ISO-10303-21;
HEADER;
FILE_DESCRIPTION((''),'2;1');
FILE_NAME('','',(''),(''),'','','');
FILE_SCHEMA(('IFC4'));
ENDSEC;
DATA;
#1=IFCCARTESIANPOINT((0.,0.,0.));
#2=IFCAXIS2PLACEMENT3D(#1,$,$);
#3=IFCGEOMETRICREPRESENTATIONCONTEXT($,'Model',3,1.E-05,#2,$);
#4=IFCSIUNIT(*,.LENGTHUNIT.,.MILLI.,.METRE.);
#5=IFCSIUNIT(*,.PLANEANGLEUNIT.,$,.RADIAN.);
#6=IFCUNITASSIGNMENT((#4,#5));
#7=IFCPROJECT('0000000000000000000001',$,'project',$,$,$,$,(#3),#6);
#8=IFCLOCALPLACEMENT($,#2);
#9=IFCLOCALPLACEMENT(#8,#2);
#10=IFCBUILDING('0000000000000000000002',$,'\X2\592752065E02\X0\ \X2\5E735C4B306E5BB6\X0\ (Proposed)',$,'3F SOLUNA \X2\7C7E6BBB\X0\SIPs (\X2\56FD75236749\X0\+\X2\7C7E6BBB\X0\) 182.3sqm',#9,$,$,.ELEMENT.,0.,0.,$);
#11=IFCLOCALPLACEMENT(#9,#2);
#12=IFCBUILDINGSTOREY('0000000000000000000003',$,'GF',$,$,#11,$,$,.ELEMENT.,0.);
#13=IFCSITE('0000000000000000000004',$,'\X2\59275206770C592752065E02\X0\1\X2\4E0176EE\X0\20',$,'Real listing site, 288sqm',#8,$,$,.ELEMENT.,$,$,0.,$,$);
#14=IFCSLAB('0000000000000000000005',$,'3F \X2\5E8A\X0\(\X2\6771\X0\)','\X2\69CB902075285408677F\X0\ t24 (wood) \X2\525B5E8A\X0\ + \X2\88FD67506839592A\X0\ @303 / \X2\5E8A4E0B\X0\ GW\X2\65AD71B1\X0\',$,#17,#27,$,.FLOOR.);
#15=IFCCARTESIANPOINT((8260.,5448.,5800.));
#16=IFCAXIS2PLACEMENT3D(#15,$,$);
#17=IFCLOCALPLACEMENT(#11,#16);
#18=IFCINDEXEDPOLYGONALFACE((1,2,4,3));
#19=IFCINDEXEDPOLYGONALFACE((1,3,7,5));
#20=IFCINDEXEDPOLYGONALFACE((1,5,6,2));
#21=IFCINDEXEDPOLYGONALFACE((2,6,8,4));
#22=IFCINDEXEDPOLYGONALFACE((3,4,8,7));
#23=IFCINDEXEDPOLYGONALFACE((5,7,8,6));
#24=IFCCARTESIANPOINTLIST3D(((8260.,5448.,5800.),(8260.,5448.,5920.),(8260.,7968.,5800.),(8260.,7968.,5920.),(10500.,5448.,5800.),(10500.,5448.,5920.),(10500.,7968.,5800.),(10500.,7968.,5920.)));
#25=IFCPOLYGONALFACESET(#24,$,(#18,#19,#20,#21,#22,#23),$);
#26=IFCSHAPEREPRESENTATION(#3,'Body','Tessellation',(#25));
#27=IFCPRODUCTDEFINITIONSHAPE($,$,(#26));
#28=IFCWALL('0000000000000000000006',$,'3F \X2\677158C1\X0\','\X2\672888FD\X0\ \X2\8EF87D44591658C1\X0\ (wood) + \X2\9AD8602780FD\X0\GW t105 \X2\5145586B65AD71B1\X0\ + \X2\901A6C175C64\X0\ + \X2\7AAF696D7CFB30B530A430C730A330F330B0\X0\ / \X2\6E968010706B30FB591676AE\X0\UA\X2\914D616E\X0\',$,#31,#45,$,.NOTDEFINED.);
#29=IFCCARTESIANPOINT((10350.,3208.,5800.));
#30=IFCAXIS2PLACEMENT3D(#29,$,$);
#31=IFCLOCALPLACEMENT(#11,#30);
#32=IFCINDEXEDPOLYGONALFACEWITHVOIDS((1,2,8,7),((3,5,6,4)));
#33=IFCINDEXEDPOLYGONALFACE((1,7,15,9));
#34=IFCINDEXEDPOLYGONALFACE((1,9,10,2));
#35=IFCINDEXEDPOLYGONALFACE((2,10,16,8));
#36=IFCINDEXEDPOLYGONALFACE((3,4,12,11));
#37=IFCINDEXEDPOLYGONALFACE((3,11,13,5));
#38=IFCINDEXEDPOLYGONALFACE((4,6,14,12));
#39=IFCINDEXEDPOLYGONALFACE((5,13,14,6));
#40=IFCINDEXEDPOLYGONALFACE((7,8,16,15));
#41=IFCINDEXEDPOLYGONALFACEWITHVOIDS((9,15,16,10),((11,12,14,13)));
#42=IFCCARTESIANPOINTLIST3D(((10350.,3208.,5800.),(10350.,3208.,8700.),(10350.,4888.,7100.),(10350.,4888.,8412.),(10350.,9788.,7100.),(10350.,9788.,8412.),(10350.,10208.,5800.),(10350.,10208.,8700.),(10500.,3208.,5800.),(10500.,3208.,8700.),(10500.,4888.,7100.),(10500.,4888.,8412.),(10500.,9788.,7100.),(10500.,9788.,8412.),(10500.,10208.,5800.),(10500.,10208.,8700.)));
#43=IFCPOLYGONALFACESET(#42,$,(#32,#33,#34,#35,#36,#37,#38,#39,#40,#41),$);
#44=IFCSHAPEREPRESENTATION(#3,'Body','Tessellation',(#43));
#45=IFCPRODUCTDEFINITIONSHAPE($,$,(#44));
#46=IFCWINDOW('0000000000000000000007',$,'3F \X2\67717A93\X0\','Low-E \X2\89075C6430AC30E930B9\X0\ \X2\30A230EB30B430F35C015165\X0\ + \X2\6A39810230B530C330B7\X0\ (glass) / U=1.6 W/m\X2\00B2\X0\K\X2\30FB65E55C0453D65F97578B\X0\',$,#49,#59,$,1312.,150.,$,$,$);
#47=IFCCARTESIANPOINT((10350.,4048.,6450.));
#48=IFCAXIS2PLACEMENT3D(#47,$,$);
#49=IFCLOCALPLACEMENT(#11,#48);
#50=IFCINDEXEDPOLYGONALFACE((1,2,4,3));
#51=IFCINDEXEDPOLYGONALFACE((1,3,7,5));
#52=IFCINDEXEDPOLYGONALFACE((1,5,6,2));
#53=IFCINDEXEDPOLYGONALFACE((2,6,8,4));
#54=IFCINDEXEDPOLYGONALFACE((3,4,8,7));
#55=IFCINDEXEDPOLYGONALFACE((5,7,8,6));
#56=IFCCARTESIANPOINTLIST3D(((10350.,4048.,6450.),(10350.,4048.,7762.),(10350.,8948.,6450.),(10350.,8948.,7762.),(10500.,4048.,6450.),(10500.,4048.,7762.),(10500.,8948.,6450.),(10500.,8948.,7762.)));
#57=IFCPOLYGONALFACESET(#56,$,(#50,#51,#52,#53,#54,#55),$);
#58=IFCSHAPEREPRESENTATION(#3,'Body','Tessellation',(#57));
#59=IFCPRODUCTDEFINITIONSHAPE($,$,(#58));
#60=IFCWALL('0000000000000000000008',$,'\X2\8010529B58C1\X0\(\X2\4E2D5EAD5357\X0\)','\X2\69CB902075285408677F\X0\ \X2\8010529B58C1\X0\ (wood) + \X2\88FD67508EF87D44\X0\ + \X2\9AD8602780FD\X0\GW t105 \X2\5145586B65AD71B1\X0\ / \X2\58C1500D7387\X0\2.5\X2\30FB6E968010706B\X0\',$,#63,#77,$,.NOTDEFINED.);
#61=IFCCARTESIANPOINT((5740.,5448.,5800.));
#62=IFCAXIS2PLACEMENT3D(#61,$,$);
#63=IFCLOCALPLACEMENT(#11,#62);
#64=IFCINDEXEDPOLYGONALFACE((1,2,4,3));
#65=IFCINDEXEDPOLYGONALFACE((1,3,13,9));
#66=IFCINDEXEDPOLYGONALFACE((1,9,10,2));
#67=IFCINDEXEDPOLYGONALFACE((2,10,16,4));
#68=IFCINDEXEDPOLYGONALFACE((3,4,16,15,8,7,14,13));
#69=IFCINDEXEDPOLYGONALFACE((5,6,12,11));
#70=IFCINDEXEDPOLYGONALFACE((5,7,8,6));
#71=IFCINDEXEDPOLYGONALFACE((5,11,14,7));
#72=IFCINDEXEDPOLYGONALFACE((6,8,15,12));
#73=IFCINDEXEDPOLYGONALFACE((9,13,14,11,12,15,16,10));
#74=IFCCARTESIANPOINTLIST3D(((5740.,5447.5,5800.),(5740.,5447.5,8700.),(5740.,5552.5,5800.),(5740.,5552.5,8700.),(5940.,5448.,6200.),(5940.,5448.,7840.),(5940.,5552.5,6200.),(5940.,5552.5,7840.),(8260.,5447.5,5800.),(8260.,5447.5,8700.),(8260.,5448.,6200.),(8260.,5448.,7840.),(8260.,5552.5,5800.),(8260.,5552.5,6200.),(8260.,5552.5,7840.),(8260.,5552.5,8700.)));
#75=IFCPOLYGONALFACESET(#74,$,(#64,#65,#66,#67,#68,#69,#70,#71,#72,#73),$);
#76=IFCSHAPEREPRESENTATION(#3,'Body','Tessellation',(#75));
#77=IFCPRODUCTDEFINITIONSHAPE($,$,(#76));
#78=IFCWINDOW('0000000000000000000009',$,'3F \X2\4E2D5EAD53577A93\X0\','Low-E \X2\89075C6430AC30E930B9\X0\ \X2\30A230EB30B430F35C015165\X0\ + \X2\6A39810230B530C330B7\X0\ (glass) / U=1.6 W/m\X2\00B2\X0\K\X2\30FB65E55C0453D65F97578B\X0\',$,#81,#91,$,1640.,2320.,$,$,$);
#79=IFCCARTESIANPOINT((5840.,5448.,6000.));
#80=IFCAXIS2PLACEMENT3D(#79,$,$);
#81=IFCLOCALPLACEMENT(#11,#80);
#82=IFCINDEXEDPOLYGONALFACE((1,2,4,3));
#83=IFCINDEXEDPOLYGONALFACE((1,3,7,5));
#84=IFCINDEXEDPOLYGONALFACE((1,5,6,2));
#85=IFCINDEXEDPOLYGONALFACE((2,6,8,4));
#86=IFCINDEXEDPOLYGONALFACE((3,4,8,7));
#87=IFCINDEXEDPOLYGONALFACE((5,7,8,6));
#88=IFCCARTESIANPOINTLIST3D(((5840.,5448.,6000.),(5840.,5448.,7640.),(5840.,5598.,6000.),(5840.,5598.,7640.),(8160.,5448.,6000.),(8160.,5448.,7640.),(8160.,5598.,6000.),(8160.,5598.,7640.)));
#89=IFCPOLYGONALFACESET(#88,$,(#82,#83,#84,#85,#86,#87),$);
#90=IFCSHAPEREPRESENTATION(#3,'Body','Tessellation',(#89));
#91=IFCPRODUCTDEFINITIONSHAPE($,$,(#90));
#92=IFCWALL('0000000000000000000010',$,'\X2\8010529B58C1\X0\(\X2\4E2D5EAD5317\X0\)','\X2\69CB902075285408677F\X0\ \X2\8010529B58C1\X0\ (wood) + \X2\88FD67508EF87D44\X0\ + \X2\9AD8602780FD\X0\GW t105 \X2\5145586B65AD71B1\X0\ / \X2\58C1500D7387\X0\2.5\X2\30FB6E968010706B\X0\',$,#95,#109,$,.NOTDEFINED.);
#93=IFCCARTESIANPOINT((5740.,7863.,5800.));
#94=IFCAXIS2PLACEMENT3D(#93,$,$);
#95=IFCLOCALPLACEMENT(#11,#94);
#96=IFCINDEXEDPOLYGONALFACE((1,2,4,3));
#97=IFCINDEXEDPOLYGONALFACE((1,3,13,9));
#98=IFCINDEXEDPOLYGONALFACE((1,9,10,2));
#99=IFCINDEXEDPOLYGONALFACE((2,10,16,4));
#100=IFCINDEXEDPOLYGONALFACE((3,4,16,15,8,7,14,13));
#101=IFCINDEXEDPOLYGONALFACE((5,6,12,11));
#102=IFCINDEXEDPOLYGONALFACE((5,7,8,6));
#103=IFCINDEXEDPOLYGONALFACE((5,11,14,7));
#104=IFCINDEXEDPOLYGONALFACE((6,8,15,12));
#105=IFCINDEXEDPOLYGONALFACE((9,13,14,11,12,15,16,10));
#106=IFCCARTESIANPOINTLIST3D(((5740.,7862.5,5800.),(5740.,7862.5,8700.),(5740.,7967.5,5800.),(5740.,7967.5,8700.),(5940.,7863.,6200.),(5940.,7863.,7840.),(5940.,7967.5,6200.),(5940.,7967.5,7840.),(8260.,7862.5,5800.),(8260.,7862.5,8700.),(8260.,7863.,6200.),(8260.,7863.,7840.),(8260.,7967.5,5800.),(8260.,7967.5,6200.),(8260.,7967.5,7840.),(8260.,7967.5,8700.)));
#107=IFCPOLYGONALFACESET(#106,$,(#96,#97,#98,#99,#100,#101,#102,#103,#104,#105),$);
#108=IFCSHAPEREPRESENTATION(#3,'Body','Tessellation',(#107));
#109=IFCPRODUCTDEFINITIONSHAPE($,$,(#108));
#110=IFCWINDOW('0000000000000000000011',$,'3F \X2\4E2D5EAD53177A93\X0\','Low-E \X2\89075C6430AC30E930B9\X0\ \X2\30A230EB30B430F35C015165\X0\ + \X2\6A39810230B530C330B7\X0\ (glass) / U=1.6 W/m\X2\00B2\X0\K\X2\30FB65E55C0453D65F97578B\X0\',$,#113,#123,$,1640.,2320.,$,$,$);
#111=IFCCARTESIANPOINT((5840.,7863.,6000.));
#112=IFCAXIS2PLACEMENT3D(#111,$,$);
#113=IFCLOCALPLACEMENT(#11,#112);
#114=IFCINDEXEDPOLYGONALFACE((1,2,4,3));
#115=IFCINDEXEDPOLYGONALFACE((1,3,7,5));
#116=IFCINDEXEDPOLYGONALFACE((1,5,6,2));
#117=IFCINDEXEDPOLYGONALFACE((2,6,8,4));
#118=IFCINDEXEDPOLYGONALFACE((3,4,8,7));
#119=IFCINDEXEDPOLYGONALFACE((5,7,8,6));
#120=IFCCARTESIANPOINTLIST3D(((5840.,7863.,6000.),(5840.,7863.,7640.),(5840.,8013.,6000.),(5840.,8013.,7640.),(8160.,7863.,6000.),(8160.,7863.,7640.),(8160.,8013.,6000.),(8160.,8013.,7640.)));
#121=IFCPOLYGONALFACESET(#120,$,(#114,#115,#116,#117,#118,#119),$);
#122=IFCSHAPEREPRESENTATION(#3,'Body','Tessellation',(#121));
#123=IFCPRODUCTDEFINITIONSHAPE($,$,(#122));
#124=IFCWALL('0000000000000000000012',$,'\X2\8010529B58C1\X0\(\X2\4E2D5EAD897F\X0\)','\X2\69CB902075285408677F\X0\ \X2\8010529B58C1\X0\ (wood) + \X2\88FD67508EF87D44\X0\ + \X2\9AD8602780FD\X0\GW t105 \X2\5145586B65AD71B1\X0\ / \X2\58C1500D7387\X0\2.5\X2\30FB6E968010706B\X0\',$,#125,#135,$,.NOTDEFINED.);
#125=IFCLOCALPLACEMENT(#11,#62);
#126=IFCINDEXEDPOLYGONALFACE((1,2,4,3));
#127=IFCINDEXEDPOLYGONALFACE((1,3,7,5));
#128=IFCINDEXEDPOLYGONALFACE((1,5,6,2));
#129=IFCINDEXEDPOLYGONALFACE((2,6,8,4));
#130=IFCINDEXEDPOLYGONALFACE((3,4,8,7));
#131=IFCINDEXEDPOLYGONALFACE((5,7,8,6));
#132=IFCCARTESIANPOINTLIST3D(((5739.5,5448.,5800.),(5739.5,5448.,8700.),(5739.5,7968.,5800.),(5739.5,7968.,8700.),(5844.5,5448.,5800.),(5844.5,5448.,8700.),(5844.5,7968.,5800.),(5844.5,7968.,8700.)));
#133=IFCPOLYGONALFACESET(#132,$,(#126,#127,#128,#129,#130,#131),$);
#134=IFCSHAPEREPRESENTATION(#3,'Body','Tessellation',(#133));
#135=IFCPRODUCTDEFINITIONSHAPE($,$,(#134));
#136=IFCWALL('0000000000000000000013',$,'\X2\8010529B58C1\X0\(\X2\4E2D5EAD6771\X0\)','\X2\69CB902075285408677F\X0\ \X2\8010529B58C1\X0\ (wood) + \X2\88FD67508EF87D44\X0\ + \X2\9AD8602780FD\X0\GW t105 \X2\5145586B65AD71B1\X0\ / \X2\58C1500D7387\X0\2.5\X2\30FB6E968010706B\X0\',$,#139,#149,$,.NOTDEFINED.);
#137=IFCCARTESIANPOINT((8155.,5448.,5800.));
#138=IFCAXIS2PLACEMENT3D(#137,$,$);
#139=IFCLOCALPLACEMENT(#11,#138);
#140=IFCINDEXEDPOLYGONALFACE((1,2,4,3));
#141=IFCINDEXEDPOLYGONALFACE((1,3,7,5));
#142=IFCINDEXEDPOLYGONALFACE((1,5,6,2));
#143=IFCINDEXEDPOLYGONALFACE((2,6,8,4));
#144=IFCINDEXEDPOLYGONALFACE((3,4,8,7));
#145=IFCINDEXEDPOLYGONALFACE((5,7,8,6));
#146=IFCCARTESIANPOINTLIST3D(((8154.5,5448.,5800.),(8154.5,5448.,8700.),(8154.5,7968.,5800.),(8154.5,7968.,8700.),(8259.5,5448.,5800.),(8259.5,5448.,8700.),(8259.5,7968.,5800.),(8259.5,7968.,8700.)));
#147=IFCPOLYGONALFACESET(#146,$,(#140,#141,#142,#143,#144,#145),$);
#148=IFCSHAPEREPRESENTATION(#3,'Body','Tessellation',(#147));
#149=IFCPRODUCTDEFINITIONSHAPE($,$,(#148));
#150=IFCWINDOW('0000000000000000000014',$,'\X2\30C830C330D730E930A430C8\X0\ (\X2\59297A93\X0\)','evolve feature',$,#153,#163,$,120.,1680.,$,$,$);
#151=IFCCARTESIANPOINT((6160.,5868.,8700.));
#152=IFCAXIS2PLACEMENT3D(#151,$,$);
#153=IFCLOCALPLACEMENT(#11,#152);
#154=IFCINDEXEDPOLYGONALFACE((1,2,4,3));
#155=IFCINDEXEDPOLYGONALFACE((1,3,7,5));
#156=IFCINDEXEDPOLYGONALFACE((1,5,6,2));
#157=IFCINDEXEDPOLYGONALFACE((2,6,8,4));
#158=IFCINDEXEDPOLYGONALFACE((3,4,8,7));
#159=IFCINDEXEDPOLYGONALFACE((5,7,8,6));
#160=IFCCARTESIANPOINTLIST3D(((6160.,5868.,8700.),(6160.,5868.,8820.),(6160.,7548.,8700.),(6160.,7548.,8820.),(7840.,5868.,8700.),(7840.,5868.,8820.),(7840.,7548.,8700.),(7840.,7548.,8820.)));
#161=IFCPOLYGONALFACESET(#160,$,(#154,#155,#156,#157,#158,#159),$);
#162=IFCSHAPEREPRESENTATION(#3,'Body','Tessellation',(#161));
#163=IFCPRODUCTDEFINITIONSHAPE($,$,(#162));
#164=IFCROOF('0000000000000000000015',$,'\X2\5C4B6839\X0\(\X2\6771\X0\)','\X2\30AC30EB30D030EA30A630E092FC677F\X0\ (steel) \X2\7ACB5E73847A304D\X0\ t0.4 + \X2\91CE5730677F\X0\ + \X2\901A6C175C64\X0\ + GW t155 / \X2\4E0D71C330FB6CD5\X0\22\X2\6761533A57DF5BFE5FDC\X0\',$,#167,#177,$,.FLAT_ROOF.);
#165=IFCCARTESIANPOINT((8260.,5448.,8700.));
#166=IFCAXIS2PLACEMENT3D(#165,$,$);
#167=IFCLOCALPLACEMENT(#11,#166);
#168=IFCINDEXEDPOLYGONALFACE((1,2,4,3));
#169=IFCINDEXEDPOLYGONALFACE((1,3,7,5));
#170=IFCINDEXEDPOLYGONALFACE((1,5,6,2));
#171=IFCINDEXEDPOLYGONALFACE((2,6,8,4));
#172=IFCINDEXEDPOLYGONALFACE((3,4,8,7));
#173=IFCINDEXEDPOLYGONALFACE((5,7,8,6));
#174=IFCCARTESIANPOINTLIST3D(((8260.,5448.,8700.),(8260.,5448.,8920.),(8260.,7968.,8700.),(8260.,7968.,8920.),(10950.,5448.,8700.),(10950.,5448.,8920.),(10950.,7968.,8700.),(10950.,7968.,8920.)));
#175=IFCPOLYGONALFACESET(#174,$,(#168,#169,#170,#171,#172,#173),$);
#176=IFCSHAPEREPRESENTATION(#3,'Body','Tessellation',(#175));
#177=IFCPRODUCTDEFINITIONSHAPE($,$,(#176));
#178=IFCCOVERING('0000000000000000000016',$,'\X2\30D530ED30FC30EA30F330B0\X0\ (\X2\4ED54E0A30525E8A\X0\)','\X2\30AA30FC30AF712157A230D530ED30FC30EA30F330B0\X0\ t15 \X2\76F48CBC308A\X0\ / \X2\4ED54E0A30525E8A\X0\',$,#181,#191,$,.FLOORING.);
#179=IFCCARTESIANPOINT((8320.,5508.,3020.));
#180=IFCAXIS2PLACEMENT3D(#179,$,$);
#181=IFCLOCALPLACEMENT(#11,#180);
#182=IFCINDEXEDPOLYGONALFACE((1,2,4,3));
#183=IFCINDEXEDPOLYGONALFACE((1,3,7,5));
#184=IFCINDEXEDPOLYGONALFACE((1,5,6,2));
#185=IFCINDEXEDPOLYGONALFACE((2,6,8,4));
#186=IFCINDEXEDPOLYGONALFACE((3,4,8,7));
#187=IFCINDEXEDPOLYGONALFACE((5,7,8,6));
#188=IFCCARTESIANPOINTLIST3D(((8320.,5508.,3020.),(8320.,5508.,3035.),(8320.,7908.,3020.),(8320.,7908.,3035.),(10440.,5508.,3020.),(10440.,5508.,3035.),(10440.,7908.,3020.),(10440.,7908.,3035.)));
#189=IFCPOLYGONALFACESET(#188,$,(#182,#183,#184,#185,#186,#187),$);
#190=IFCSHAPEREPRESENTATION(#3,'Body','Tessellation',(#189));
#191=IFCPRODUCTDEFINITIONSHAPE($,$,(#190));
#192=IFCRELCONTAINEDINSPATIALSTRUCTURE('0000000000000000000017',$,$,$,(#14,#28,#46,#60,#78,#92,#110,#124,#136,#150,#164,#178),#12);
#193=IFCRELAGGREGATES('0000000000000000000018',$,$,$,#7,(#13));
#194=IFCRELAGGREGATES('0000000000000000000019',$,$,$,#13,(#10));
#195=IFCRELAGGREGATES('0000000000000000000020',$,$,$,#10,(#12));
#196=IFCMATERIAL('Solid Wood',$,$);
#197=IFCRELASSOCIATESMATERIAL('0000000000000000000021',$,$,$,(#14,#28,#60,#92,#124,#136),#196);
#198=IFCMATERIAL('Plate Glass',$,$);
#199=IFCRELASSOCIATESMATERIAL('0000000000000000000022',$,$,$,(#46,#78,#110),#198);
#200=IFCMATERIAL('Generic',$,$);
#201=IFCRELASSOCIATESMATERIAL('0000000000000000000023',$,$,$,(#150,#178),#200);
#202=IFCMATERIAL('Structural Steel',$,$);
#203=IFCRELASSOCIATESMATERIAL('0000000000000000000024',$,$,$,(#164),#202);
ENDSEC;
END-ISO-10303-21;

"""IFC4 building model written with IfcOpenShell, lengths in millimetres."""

from ifc_helpers import new_model, si_unit, frame, frame_2d, origin, place, context, project, spatial, rectangle, extrude, material, element, fill, save


model = new_model("IFC4")

# Units and contexts
model_context = context("Model", 3, precision=1e-05, world=origin())
ifc_project = project(units=[si_unit("LENGTHUNIT", "METRE", prefix="MILLI"), si_unit("PLANEANGLEUNIT", "RADIAN")], contexts=[model_context])

# Site, building, storey
site_placement = place(None, origin())
site = spatial("IfcSite", under=ifc_project, at=site_placement, Name="大分県大分市1丁目20", ObjectType="Real listing site, 288sqm", CompositionType="ELEMENT", RefElevation=0.0)
building_placement = place(site_placement, origin())
building = spatial("IfcBuilding", under=site, at=building_placement, Name="大分市 平屋の家 (Proposed)", ObjectType="3F SOLUNA 籾殻SIPs (国産杉+籾殻) 182.3sqm", CompositionType="ELEMENT", ElevationOfRefHeight=0.0, ElevationOfTerrain=0.0)
storey_placement = place(building_placement, origin())
storey = spatial("IfcBuildingStorey", under=building, at=storey_placement, Name="GF", CompositionType="ELEMENT", Elevation=0.0)

# Slab
ifc_material_1 = material(Name="Solid Wood")
slab_placement = place(storey_placement, frame((8260.0, 5448.0, 5800.0)))
element("IfcSlab", 1, at=slab_placement, inside=storey, material=ifc_material_1, Name="3F 床(東)", Description="構造用合板 t24 (wood) 剛床 + 製材根太 @303 / 床下 GW断熱", PredefinedType="FLOOR", context=model_context, shape_type="SweptSolid", body=[
    extrude(rectangle(XDim=2240.0, YDim=2520.0, at=frame_2d((1120.0, 1260.0))), frame((8260.0, 5448.0, 5800.0)), (0.0, 0.0, 1.0), 120.0),
])

# Walls, openings, windows
wall_1_placement = place(storey_placement, frame((10350.0, 3208.0, 5800.0)))
wall_1 = element("IfcWall", 2, at=wall_1_placement, inside=storey, material=ifc_material_1, Name="3F 東壁", Description="木製 軸組外壁 (wood) + 高性能GW t105 充填断熱 + 通気層 + 窯業系サイディング / 準耐火・外皮UA配慮", PredefinedType="NOTDEFINED", context=model_context, shape_type="SweptSolid", body=[
    extrude(rectangle(XDim=150.0, YDim=7000.0, at=frame_2d((75.0, 3500.0))), frame((10350.0, 3208.0, 5800.0)), (0.0, 0.0, 1.0), 2900.0),
])
opening_1_placement = place(storey_placement, frame((10350.0, 4048.0, 6450.0)))
opening_1 = element("IfcOpeningElement", 3, at=opening_1_placement, cuts=wall_1, PredefinedType="NOTDEFINED", context=model_context, shape_type="SweptSolid", body=[
    extrude(rectangle(XDim=150.0, YDim=4900.0, at=frame_2d((75.0, 2450.0))), frame((10350.0, 4048.0, 6450.0)), (0.0, 0.0, 1.0), 1312.0),
])
ifc_material_2 = material(Name="Plate Glass")
window_1_placement = place(storey_placement, frame((10350.0, 4048.0, 6450.0)))
window_1 = element("IfcWindow", 4, at=window_1_placement, inside=storey, material=ifc_material_2, Name="3F 東窓", Description="Low-E 複層ガラス アルゴン封入 + 樹脂サッシ (glass) / U=1.6 W/m²K・日射取得型", OverallHeight=1312.0, OverallWidth=150.0, context=model_context, shape_type="SweptSolid", body=[
    extrude(rectangle(XDim=150.0, YDim=4900.0, at=frame_2d((75.0, 2450.0))), frame((10350.0, 4048.0, 6450.0)), (0.0, 0.0, 1.0), 1312.0),
])
fill(opening_1, window_1)
wall_2_placement = place(storey_placement, frame((5740.0, 5448.0, 5800.0)))
wall_2 = element("IfcWall", 5, at=wall_2_placement, inside=storey, material=ifc_material_1, Name="耐力壁(中庭南)", Description="構造用合板 耐力壁 (wood) + 製材軸組 + 高性能GW t105 充填断熱 / 壁倍率2.5・準耐火", PredefinedType="NOTDEFINED", context=model_context, shape_type="SweptSolid", body=[
    extrude(rectangle(XDim=2520.0, YDim=105.0, at=frame_2d((1260.0, 52.0))), frame((5740.0, 5448.0, 5800.0)), (0.0, 0.0, 1.0), 2900.0),
])
opening_2_placement = place(storey_placement, frame((5840.0, 5448.0, 6000.0)))
opening_2 = element("IfcOpeningElement", 6, at=opening_2_placement, cuts=wall_2, PredefinedType="NOTDEFINED", context=model_context, shape_type="SweptSolid", body=[
    extrude(rectangle(XDim=2320.0, YDim=150.0, at=frame_2d((1160.0, 75.0))), frame((5840.0, 5448.0, 6000.0)), (0.0, 0.0, 1.0), 1640.0),
])
window_2_placement = place(storey_placement, frame((5840.0, 5448.0, 6000.0)))
window_2 = element("IfcWindow", 7, at=window_2_placement, inside=storey, material=ifc_material_2, Name="3F 中庭南窓", Description="Low-E 複層ガラス アルゴン封入 + 樹脂サッシ (glass) / U=1.6 W/m²K・日射取得型", OverallHeight=1640.0, OverallWidth=2320.0, context=model_context, shape_type="SweptSolid", body=[
    extrude(rectangle(XDim=2320.0, YDim=150.0, at=frame_2d((1160.0, 75.0))), frame((5840.0, 5448.0, 6000.0)), (0.0, 0.0, 1.0), 1640.0),
])
fill(opening_2, window_2)
wall_3_placement = place(storey_placement, frame((5740.0, 7863.0, 5800.0)))
wall_3 = element("IfcWall", 8, at=wall_3_placement, inside=storey, material=ifc_material_1, Name="耐力壁(中庭北)", Description="構造用合板 耐力壁 (wood) + 製材軸組 + 高性能GW t105 充填断熱 / 壁倍率2.5・準耐火", PredefinedType="NOTDEFINED", context=model_context, shape_type="SweptSolid", body=[
    extrude(rectangle(XDim=2520.0, YDim=105.0, at=frame_2d((1260.0, 52.0))), frame((5740.0, 7863.0, 5800.0)), (0.0, 0.0, 1.0), 2900.0),
])
opening_3_placement = place(storey_placement, frame((5840.0, 7863.0, 6000.0)))
opening_3 = element("IfcOpeningElement", 9, at=opening_3_placement, cuts=wall_3, PredefinedType="NOTDEFINED", context=model_context, shape_type="SweptSolid", body=[
    extrude(rectangle(XDim=2320.0, YDim=150.0, at=frame_2d((1160.0, 75.0))), frame((5840.0, 7863.0, 6000.0)), (0.0, 0.0, 1.0), 1640.0),
])
window_3_placement = place(storey_placement, frame((5840.0, 7863.0, 6000.0)))
window_3 = element("IfcWindow", 10, at=window_3_placement, inside=storey, material=ifc_material_2, Name="3F 中庭北窓", Description="Low-E 複層ガラス アルゴン封入 + 樹脂サッシ (glass) / U=1.6 W/m²K・日射取得型", OverallHeight=1640.0, OverallWidth=2320.0, context=model_context, shape_type="SweptSolid", body=[
    extrude(rectangle(XDim=2320.0, YDim=150.0, at=frame_2d((1160.0, 75.0))), frame((5840.0, 7863.0, 6000.0)), (0.0, 0.0, 1.0), 1640.0),
])
fill(opening_3, window_3)

# Walls
wall_4_placement = place(storey_placement, frame((5740.0, 5448.0, 5800.0)))
element("IfcWall", 11, at=wall_4_placement, inside=storey, material=ifc_material_1, Name="耐力壁(中庭西)", Description="構造用合板 耐力壁 (wood) + 製材軸組 + 高性能GW t105 充填断熱 / 壁倍率2.5・準耐火", PredefinedType="NOTDEFINED", context=model_context, shape_type="SweptSolid", body=[
    extrude(rectangle(XDim=105.0, YDim=2520.0, at=frame_2d((52.0, 1260.0))), frame((5740.0, 5448.0, 5800.0)), (0.0, 0.0, 1.0), 2900.0),
])
wall_5_placement = place(storey_placement, frame((8155.0, 5448.0, 5800.0)))
element("IfcWall", 12, at=wall_5_placement, inside=storey, material=ifc_material_1, Name="耐力壁(中庭東)", Description="構造用合板 耐力壁 (wood) + 製材軸組 + 高性能GW t105 充填断熱 / 壁倍率2.5・準耐火", PredefinedType="NOTDEFINED", context=model_context, shape_type="SweptSolid", body=[
    extrude(rectangle(XDim=105.0, YDim=2520.0, at=frame_2d((52.0, 1260.0))), frame((8155.0, 5448.0, 5800.0)), (0.0, 0.0, 1.0), 2900.0),
])

# Window
ifc_material_3 = material(Name="Generic")
window_4_placement = place(storey_placement, frame((6160.0, 5868.0, 8700.0)))
element("IfcWindow", 13, at=window_4_placement, inside=storey, material=ifc_material_3, Name="トップライト (天窓)", Description="evolve feature", OverallHeight=120.0, OverallWidth=1680.0, context=model_context, shape_type="SweptSolid", body=[
    extrude(rectangle(XDim=1680.0, YDim=1680.0, at=frame_2d((840.0, 840.0))), frame((6160.0, 5868.0, 8700.0)), (0.0, 0.0, 1.0), 120.0),
])

# Roof
ifc_material_4 = material(Name="Structural Steel")
for number, where, name in (
    (14, (8260.0, 5448.0, 8700.0), "屋根(東)"),
):
    element("IfcRoof", number, at=place(storey_placement, frame(where)), inside=storey, material=ifc_material_4, Name=name, Description="ガルバリウム鋼板 (steel) 立平葺き t0.4 + 野地板 + 通気層 + GW t155 / 不燃・法22条区域対応", PredefinedType="FLAT_ROOF", context=model_context, shape_type="SweptSolid", body=[
        extrude(rectangle(XDim=2690.0, YDim=2520.0, at=frame_2d((1345.0, 1260.0))), frame((8260.0, 5448.0, 8700.0)), (0.0, 0.0, 1.0), 220.0),
    ])

# Covering
covering_1_placement = place(storey_placement, frame((8320.0, 5508.0, 3020.0)))
element("IfcCovering", 15, at=covering_1_placement, inside=storey, material=ifc_material_3, Name="フローリング (仕上げ床)", Description="オーク無垢フローリング t15 直貼り / 仕上げ床", PredefinedType="FLOORING", context=model_context, shape_type="SweptSolid", body=[
    extrude(rectangle(XDim=2120.0, YDim=2400.0, at=frame_2d((1060.0, 1200.0))), frame((8320.0, 5508.0, 3020.0)), (0.0, 0.0, 1.0), 15.0),
])

save(model, "model.ifc")
